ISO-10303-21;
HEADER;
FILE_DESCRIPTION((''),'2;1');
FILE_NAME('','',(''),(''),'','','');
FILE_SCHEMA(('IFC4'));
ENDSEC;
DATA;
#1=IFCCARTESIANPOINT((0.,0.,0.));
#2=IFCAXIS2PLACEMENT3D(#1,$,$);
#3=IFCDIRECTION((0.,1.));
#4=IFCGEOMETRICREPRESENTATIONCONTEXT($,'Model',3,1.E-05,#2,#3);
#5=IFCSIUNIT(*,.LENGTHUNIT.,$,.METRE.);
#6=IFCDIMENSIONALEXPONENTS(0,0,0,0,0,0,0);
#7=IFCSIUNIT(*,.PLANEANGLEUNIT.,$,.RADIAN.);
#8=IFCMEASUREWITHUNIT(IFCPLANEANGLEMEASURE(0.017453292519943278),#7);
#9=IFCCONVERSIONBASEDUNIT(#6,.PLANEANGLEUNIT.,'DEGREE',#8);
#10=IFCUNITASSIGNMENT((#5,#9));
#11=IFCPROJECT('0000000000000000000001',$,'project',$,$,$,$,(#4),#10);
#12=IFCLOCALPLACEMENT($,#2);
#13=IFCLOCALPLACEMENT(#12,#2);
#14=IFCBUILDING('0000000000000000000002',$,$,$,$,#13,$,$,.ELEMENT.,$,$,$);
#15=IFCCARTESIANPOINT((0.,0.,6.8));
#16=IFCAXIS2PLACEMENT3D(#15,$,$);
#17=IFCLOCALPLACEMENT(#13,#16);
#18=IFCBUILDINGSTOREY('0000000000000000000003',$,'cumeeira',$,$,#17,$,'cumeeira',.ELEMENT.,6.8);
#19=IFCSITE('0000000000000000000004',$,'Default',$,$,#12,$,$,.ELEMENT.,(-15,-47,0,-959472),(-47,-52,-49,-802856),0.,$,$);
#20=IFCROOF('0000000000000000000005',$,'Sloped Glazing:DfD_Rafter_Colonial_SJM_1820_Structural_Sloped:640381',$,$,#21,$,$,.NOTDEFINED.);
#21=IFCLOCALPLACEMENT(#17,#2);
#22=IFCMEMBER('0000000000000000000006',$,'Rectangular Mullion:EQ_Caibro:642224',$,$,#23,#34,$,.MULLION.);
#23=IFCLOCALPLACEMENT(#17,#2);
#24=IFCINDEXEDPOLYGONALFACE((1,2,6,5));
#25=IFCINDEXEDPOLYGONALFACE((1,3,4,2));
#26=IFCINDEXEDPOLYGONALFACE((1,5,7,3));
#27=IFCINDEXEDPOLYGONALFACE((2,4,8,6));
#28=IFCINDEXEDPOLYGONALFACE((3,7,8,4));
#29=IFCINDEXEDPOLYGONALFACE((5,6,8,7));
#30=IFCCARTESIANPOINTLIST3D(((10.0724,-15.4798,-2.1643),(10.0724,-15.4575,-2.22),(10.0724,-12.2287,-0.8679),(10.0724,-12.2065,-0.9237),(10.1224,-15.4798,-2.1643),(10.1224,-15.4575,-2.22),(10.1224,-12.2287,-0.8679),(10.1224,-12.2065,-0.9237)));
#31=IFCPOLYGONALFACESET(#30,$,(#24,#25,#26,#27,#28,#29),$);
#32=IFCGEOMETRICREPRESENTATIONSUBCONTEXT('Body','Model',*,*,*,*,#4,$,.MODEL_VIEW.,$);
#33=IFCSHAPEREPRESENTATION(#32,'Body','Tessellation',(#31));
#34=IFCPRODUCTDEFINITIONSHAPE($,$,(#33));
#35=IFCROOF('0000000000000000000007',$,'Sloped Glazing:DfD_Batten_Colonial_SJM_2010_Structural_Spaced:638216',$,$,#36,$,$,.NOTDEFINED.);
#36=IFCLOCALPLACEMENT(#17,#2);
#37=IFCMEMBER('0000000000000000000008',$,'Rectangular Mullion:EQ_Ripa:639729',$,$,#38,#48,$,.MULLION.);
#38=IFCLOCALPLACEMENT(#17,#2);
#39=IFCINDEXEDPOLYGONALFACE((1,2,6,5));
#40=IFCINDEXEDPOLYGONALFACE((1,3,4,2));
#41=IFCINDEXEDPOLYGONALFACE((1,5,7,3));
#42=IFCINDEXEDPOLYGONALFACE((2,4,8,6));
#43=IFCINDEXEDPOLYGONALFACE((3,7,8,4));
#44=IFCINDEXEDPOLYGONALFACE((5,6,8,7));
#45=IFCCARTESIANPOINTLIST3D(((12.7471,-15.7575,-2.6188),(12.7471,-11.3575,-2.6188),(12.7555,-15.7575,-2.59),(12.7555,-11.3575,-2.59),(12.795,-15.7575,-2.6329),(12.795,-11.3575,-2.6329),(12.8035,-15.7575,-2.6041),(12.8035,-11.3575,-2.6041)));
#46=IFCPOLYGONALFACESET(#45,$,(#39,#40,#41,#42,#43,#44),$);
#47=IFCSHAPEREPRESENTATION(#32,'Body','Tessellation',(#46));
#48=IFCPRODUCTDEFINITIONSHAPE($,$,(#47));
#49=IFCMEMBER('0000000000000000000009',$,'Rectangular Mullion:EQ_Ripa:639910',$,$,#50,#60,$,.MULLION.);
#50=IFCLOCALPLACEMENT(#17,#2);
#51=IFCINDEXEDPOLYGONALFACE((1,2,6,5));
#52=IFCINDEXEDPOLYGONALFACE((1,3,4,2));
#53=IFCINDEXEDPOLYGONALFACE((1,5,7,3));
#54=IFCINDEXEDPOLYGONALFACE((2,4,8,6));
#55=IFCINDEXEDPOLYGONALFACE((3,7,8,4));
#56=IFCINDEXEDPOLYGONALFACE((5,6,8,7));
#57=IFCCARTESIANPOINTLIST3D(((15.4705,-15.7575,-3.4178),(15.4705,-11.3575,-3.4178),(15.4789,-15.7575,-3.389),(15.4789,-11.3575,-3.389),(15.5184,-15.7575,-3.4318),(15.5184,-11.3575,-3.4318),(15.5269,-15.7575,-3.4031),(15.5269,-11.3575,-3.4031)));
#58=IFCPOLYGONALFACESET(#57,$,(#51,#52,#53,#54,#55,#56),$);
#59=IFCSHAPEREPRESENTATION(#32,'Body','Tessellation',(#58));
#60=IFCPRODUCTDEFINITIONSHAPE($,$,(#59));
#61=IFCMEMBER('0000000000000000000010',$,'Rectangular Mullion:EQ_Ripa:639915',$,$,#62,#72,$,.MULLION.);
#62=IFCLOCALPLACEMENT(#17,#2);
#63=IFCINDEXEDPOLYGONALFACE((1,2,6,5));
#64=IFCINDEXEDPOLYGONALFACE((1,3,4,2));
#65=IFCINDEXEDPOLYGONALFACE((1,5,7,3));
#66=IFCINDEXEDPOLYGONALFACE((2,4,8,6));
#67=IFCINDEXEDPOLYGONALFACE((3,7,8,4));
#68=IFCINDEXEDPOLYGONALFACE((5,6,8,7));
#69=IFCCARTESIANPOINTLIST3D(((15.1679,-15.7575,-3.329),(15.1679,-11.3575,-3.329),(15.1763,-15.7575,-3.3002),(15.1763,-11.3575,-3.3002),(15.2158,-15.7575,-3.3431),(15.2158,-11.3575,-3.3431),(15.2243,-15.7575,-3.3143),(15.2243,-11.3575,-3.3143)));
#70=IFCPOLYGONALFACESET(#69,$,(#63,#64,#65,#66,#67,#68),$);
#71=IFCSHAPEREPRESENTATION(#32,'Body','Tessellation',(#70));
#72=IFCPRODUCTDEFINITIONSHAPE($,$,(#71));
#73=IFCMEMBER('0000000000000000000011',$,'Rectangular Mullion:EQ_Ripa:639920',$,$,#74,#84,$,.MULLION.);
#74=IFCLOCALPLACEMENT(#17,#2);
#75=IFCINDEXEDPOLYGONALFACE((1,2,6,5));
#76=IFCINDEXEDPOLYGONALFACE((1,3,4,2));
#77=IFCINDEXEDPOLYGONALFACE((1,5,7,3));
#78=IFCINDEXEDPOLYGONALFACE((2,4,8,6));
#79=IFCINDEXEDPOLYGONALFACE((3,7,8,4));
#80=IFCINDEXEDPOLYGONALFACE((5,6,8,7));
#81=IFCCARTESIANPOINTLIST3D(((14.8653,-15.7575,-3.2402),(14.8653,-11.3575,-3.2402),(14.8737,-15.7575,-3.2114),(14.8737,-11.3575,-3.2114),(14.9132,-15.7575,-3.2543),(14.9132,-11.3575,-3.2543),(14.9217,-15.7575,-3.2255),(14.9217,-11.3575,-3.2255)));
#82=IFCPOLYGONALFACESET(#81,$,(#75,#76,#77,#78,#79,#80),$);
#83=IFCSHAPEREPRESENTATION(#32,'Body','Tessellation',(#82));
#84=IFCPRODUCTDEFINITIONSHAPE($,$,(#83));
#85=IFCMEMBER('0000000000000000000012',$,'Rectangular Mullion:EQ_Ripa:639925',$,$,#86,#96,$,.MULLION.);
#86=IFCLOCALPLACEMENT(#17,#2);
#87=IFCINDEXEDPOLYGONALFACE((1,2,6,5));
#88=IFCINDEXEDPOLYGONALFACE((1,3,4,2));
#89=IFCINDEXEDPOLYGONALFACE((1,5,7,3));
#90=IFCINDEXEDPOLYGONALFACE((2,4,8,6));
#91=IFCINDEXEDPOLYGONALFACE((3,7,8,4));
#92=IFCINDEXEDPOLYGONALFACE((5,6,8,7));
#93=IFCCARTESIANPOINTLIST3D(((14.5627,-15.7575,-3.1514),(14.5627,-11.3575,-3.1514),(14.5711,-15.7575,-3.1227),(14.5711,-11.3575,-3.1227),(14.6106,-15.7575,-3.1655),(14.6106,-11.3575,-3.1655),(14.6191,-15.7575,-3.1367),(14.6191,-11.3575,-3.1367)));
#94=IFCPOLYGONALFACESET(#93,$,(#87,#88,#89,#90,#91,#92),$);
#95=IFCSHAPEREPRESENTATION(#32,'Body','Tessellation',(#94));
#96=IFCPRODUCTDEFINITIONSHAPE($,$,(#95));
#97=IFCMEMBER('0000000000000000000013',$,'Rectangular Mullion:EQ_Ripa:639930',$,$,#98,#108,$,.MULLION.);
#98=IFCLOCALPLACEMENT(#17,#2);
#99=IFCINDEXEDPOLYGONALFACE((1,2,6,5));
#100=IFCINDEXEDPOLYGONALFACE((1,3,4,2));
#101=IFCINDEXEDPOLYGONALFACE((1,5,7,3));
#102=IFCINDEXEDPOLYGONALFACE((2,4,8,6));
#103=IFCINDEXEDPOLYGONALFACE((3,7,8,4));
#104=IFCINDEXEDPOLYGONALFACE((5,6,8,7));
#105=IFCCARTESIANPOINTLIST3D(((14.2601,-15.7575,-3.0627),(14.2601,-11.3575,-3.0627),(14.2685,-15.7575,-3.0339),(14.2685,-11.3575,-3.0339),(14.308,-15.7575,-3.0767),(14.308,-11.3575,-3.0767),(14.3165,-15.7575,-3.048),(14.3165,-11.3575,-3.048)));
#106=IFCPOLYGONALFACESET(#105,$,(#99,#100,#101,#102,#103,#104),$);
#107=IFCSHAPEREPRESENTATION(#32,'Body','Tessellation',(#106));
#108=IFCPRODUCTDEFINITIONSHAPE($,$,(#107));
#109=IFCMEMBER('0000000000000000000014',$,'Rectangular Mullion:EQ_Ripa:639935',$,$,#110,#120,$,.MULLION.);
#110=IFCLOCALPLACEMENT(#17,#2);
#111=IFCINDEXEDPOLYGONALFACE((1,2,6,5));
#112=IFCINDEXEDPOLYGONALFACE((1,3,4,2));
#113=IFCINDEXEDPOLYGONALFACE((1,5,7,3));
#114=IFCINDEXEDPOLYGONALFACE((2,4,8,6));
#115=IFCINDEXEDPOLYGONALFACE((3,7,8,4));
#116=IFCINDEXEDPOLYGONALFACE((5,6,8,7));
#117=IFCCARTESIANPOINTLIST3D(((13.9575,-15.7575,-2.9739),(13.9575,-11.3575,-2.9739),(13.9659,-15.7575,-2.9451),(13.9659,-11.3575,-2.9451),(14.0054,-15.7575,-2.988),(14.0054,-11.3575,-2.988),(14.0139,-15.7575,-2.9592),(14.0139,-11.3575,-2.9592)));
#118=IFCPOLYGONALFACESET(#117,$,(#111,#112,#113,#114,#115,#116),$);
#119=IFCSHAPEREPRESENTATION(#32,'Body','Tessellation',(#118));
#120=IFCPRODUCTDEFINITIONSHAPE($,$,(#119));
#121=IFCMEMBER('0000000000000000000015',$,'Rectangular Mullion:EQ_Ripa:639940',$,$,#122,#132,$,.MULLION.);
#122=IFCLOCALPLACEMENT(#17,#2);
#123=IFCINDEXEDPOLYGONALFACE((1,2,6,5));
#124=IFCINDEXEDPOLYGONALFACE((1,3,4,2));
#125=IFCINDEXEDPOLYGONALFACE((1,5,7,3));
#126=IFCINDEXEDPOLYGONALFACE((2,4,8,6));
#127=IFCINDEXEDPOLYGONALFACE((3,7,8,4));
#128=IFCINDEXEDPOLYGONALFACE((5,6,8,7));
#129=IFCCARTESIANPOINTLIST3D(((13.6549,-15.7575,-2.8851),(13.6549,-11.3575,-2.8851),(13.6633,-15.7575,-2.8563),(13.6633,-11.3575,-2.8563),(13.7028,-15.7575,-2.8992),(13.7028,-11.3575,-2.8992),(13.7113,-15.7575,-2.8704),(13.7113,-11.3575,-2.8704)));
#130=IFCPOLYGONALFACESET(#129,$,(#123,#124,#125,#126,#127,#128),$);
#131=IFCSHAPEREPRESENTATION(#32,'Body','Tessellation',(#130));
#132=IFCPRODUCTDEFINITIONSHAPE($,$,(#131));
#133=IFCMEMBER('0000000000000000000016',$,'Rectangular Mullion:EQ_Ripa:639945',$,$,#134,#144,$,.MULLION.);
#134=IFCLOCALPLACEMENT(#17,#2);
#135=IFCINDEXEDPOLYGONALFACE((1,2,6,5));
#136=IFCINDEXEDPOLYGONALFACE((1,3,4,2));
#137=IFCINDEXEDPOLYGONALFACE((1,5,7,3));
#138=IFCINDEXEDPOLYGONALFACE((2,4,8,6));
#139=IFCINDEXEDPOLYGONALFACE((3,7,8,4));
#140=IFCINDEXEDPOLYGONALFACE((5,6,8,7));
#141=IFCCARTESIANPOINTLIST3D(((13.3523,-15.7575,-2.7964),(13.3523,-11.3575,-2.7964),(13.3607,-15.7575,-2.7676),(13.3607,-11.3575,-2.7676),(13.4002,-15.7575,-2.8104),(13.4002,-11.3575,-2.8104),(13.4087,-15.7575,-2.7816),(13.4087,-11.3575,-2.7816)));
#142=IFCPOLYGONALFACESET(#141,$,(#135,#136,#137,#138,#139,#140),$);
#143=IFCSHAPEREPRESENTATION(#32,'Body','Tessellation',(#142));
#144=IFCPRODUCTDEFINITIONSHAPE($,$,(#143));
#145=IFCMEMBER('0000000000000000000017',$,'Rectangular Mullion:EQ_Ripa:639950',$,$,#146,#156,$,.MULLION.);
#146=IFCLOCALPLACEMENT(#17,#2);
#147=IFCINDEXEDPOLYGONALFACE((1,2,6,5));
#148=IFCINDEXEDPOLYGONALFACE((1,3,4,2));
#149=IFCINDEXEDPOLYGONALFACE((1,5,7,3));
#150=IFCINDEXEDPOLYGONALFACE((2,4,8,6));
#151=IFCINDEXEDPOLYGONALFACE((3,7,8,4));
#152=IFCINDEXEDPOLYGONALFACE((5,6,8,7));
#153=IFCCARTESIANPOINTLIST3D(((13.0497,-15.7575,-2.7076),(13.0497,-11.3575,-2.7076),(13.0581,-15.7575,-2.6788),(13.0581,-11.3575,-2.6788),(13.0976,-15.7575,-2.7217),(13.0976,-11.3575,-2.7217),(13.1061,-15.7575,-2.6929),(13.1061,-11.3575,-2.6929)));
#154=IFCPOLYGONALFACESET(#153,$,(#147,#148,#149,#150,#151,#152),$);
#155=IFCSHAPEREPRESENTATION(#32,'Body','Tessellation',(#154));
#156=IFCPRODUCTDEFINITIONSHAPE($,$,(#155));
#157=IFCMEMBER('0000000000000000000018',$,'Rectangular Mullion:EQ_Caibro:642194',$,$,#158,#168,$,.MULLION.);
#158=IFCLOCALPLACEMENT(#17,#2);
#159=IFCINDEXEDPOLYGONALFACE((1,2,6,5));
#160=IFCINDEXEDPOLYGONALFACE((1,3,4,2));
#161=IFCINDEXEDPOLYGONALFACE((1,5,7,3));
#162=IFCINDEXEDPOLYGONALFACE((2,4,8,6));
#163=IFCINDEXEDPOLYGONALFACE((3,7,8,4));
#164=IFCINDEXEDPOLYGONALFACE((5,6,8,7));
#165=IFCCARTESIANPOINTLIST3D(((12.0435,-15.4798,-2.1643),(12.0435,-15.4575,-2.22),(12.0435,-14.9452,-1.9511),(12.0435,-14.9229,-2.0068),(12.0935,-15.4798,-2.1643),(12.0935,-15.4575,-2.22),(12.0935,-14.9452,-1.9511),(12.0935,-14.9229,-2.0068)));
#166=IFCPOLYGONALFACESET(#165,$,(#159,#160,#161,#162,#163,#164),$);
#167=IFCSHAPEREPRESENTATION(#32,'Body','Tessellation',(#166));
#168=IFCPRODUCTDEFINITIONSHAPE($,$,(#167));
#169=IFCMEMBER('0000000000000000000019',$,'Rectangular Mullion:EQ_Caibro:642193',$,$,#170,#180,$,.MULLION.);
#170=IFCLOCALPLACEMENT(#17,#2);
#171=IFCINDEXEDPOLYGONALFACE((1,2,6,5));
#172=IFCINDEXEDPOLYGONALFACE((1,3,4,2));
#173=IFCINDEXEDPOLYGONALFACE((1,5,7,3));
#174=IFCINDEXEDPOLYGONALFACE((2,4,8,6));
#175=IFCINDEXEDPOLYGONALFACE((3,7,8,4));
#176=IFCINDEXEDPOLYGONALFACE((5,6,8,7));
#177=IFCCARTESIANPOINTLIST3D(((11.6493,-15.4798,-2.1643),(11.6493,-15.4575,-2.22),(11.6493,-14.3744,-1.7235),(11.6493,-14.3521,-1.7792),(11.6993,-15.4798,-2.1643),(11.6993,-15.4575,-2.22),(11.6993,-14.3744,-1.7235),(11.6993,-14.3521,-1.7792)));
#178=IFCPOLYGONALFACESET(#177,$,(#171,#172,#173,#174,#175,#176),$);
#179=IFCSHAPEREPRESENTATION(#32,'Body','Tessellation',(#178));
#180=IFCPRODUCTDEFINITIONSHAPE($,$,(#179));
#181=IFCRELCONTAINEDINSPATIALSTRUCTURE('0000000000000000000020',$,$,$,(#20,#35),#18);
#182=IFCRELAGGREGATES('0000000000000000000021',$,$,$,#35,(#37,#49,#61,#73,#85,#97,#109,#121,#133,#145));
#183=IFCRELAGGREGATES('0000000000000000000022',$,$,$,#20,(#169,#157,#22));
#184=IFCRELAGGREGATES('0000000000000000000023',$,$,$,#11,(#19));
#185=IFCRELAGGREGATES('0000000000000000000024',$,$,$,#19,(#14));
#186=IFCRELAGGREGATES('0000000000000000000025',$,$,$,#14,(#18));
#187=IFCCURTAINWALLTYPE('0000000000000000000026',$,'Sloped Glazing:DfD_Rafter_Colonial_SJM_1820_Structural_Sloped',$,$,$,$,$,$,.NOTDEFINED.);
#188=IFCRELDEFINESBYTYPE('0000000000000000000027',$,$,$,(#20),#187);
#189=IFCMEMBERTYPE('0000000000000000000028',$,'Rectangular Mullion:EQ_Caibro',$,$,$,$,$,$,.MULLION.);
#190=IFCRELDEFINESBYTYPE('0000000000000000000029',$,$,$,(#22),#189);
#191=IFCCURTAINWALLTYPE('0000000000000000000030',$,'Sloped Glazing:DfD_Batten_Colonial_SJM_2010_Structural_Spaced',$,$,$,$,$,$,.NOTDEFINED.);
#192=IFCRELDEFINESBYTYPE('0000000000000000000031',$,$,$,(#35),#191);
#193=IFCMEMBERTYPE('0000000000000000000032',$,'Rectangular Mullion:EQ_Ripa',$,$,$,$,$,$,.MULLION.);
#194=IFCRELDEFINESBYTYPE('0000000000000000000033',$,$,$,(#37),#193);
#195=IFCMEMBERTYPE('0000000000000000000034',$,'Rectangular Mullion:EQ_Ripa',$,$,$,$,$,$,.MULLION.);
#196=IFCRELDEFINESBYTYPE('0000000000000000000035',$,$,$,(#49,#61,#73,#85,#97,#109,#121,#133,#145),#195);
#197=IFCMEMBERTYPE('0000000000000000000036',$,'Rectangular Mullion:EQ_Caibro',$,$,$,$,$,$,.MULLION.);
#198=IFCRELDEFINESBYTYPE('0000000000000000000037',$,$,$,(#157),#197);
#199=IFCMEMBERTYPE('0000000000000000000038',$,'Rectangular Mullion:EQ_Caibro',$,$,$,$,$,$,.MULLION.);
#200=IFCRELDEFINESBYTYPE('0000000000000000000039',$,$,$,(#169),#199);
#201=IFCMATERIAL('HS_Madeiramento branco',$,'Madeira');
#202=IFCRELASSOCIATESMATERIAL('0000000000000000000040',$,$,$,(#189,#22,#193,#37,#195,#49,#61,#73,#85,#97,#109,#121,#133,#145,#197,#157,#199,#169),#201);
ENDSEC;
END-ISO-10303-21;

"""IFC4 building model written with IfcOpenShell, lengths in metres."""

from ifc_helpers import new_model, entity, si_unit, converted_unit, direction, frame, origin, place, context, subcontext, project, spatial, indexed_curve, outline, extrude, source, transform, mapped, material, type_object, type_shapes, element, aggregate, save


model = new_model("IFC4")

# Units and contexts
model_context = context("Model", 3, precision=1e-05, world=origin(), true_north=direction((0.0, 1.0)))
body_context = subcontext(model_context, "Body", "Model", "MODEL_VIEW")
ifc_project = project(units=[si_unit("LENGTHUNIT", "METRE"), converted_unit("PLANEANGLEUNIT", "DEGREE", entity("IfcPlaneAngleMeasure", 0.017453292519943278), si_unit("PLANEANGLEUNIT", "RADIAN"), dimensions=[0, 0, 0, 0, 0, 0, 0])], contexts=[model_context])

# Site, building, storey
site_placement = place(None, origin())
site = spatial("IfcSite", under=ifc_project, at=site_placement, Name="Default", CompositionType="ELEMENT", RefLatitude=(-15, -47, 0, -959472), RefLongitude=(-47, -52, -49, -802856), RefElevation=0.0)
building_placement = place(site_placement, origin())
building = spatial("IfcBuilding", under=site, at=building_placement, CompositionType="ELEMENT")
storey_placement = place(building_placement, frame((0.0, 0.0, 6.8)))
storey = spatial("IfcBuildingStorey", under=building, at=storey_placement, Name="cumeeira", LongName="cumeeira", CompositionType="ELEMENT", Elevation=6.8)

# Roof, member
curtain_wall_type_1 = type_object("IfcCurtainWallType", Name="Sloped Glazing:DfD_Rafter_Colonial_SJM_1820_Structural_Sloped", PredefinedType="NOTDEFINED")
roof_1_placement = place(storey_placement, frame((0.0, 0.0, -6.8)))
roof_1 = element("IfcRoof", 1, at=roof_1_placement, inside=storey, type_object=curtain_wall_type_1, Name="Sloped Glazing:DfD_Rafter_Colonial_SJM_1820_Structural_Sloped:640381", PredefinedType="NOTDEFINED")
ifc_material_1 = material(Name="HS_Madeiramento branco", Category="Madeira")
member_type_1 = type_object("IfcMemberType", Name="Rectangular Mullion:EQ_Caibro", PredefinedType="MULLION", material=ifc_material_1)
shared_shape_1 = source(origin(), body_context, "Body", "SweptSolid", [
    extrude(outline(indexed_curve([(-0.025, -0.03), (0.025, -0.03), (0.025, 0.03), (-0.025, 0.03), (-0.025, -0.03)], self_intersect=False)), frame((0.0, -0.03, -3.5), z_axis=(0.0, 0.0, 1.0), x_axis=(-1.0, 0.0, 0.0)), (0.0, 0.0, 1.0), 3.5),
])
type_shapes(member_type_1, [shared_shape_1])
member_1_placement = place(roof_1_placement, frame((10.0974, -12.2065, 5.8763), z_axis=(0.0, 0.928878, 0.370385), x_axis=(1.0, 0.0, 0.0)))
member_1 = element("IfcMember", 2, at=member_1_placement, type_object=member_type_1, material=ifc_material_1, Name="Rectangular Mullion:EQ_Caibro:642224", PredefinedType="MULLION", context=body_context, shape_type="MappedRepresentation", body=[
    mapped(shared_shape_1, transform((0.0, 0.0, 0.0), scale=1.0)),
])

# Roof, members
curtain_wall_type_2 = type_object("IfcCurtainWallType", Name="Sloped Glazing:DfD_Batten_Colonial_SJM_2010_Structural_Spaced", PredefinedType="NOTDEFINED")
roof_2_placement = place(storey_placement, frame((0.0, 0.0, -6.8)))
roof_2 = element("IfcRoof", 3, at=roof_2_placement, inside=storey, type_object=curtain_wall_type_2, Name="Sloped Glazing:DfD_Batten_Colonial_SJM_2010_Structural_Spaced:638216", PredefinedType="NOTDEFINED")
member_type_2 = type_object("IfcMemberType", Name="Rectangular Mullion:EQ_Ripa", PredefinedType="MULLION", material=ifc_material_1)
shared_shape_2 = source(origin(), body_context, "Body", "SweptSolid", [
    extrude(outline(indexed_curve([(-0.025, -0.015), (0.025, -0.015), (0.025, 0.015), (-0.025, 0.015), (-0.025, -0.015)], self_intersect=False)), frame((-0.025, 0.0, -4.4), z_axis=(0.0, 0.0, 1.0), x_axis=(-1.0, 0.0, 0.0)), (0.0, 0.0, 1.0), 4.4),
])
type_shapes(member_type_2, [shared_shape_2])
member_2_placement = place(roof_2_placement, frame((12.7513, -15.7575, 4.1956), z_axis=(0.0, -1.0, 0.0), x_axis=(-0.95956, 0.0, 0.281504)))
member_2 = element("IfcMember", 4, at=member_2_placement, type_object=member_type_2, material=ifc_material_1, Name="Rectangular Mullion:EQ_Ripa:639729", PredefinedType="MULLION", context=body_context, shape_type="MappedRepresentation", body=[
    mapped(shared_shape_2, transform((0.0, 0.0, 0.0), scale=1.0)),
])
member_type_3 = type_object("IfcMemberType", Name="Rectangular Mullion:EQ_Ripa", PredefinedType="MULLION", material=ifc_material_1)
shared_shape_3 = source(origin(), body_context, "Body", "SweptSolid", [
    extrude(outline(indexed_curve([(-0.025, -0.015), (0.025, -0.015), (0.025, 0.015), (-0.025, 0.015), (-0.025, -0.015)], self_intersect=False)), frame((0.0, 0.0, -4.4), z_axis=(0.0, 0.0, 1.0), x_axis=(-1.0, 0.0, 0.0)), (0.0, 0.0, 1.0), 4.4),
])
type_shapes(member_type_3, [shared_shape_3])
member_3_placement = place(roof_2_placement, frame((15.4987, -15.7575, 3.3896), z_axis=(0.0, -1.0, 0.0), x_axis=(-0.95956, 0.0, 0.281504)))
member_3 = element("IfcMember", 5, at=member_3_placement, type_object=member_type_3, material=ifc_material_1, Name="Rectangular Mullion:EQ_Ripa:639910", PredefinedType="MULLION", context=body_context, shape_type="MappedRepresentation", body=[
    mapped(shared_shape_3, transform((0.0, 0.0, 0.0), scale=1.0)),
])
member_4_placement = place(roof_2_placement, frame((15.1961, -15.7575, 3.4784), z_axis=(0.0, -1.0, 0.0), x_axis=(-0.95956, 0.0, 0.281504)))
member_4 = element("IfcMember", 6, at=member_4_placement, type_object=member_type_3, material=ifc_material_1, Name="Rectangular Mullion:EQ_Ripa:639915", PredefinedType="MULLION", context=body_context, shape_type="MappedRepresentation", body=[
    mapped(shared_shape_3, transform((0.0, 0.0, 0.0), scale=1.0)),
])
member_5_placement = place(roof_2_placement, frame((14.8935, -15.7575, 3.5671), z_axis=(0.0, -1.0, 0.0), x_axis=(-0.95956, 0.0, 0.281504)))
member_5 = element("IfcMember", 7, at=member_5_placement, type_object=member_type_3, material=ifc_material_1, Name="Rectangular Mullion:EQ_Ripa:639920", PredefinedType="MULLION", context=body_context, shape_type="MappedRepresentation", body=[
    mapped(shared_shape_3, transform((0.0, 0.0, 0.0), scale=1.0)),
])
member_6_placement = place(roof_2_placement, frame((14.5909, -15.7575, 3.6559), z_axis=(0.0, -1.0, 0.0), x_axis=(-0.95956, 0.0, 0.281504)))
member_6 = element("IfcMember", 8, at=member_6_placement, type_object=member_type_3, material=ifc_material_1, Name="Rectangular Mullion:EQ_Ripa:639925", PredefinedType="MULLION", context=body_context, shape_type="MappedRepresentation", body=[
    mapped(shared_shape_3, transform((0.0, 0.0, 0.0), scale=1.0)),
])
member_7_placement = place(roof_2_placement, frame((14.2883, -15.7575, 3.7447), z_axis=(0.0, -1.0, 0.0), x_axis=(-0.95956, 0.0, 0.281504)))
member_7 = element("IfcMember", 9, at=member_7_placement, type_object=member_type_3, material=ifc_material_1, Name="Rectangular Mullion:EQ_Ripa:639930", PredefinedType="MULLION", context=body_context, shape_type="MappedRepresentation", body=[
    mapped(shared_shape_3, transform((0.0, 0.0, 0.0), scale=1.0)),
])
member_8_placement = place(roof_2_placement, frame((13.9857, -15.7575, 3.8335), z_axis=(0.0, -1.0, 0.0), x_axis=(-0.95956, 0.0, 0.281504)))
member_8 = element("IfcMember", 10, at=member_8_placement, type_object=member_type_3, material=ifc_material_1, Name="Rectangular Mullion:EQ_Ripa:639935", PredefinedType="MULLION", context=body_context, shape_type="MappedRepresentation", body=[
    mapped(shared_shape_3, transform((0.0, 0.0, 0.0), scale=1.0)),
])
member_9_placement = place(roof_2_placement, frame((13.6831, -15.7575, 3.9222), z_axis=(0.0, -1.0, 0.0), x_axis=(-0.95956, 0.0, 0.281504)))
member_9 = element("IfcMember", 11, at=member_9_placement, type_object=member_type_3, material=ifc_material_1, Name="Rectangular Mullion:EQ_Ripa:639940", PredefinedType="MULLION", context=body_context, shape_type="MappedRepresentation", body=[
    mapped(shared_shape_3, transform((0.0, 0.0, 0.0), scale=1.0)),
])
member_10_placement = place(roof_2_placement, frame((13.3805, -15.7575, 4.011), z_axis=(0.0, -1.0, 0.0), x_axis=(-0.95956, 0.0, 0.281504)))
member_10 = element("IfcMember", 12, at=member_10_placement, type_object=member_type_3, material=ifc_material_1, Name="Rectangular Mullion:EQ_Ripa:639945", PredefinedType="MULLION", context=body_context, shape_type="MappedRepresentation", body=[
    mapped(shared_shape_3, transform((0.0, 0.0, 0.0), scale=1.0)),
])
member_11_placement = place(roof_2_placement, frame((13.0779, -15.7575, 4.0998), z_axis=(0.0, -1.0, 0.0), x_axis=(-0.95956, 0.0, 0.281504)))
member_11 = element("IfcMember", 13, at=member_11_placement, type_object=member_type_3, material=ifc_material_1, Name="Rectangular Mullion:EQ_Ripa:639950", PredefinedType="MULLION", context=body_context, shape_type="MappedRepresentation", body=[
    mapped(shared_shape_3, transform((0.0, 0.0, 0.0), scale=1.0)),
])
aggregate(roof_2, [member_2, member_3, member_4, member_5, member_6, member_7, member_8, member_9, member_10, member_11])

# Members
member_type_4 = type_object("IfcMemberType", Name="Rectangular Mullion:EQ_Caibro", PredefinedType="MULLION", material=ifc_material_1)
shared_shape_4 = source(origin(), body_context, "Body", "SweptSolid", [
    extrude(outline(indexed_curve([(-0.025, -0.03), (0.025, -0.03), (0.025, 0.03), (-0.025, 0.03), (-0.025, -0.03)], self_intersect=False)), frame((0.0, -0.03, -0.5755), z_axis=(0.0, 0.0, 1.0), x_axis=(-1.0, 0.0, 0.0)), (0.0, 0.0, 1.0), 0.5755),
])
type_shapes(member_type_4, [shared_shape_4])
member_12_placement = place(roof_1_placement, frame((12.0685, -14.9229, 4.7932), z_axis=(0.0, 0.928878, 0.370385), x_axis=(1.0, 0.0, 0.0)))
member_12 = element("IfcMember", 14, at=member_12_placement, type_object=member_type_4, material=ifc_material_1, Name="Rectangular Mullion:EQ_Caibro:642194", PredefinedType="MULLION", context=body_context, shape_type="MappedRepresentation", body=[
    mapped(shared_shape_4, transform((0.0, 0.0, 0.0), scale=1.0)),
])
member_type_5 = type_object("IfcMemberType", Name="Rectangular Mullion:EQ_Caibro", PredefinedType="MULLION", material=ifc_material_1)
shared_shape_5 = source(origin(), body_context, "Body", "SweptSolid", [
    extrude(outline(indexed_curve([(-0.025, -0.03), (0.025, -0.03), (0.025, 0.03), (-0.025, 0.03), (-0.025, -0.03)], self_intersect=False)), frame((0.0, -0.03, -1.19), z_axis=(0.0, 0.0, 1.0), x_axis=(-1.0, 0.0, 0.0)), (0.0, 0.0, 1.0), 1.19),
])
type_shapes(member_type_5, [shared_shape_5])
member_13_placement = place(roof_1_placement, frame((11.6743, -14.3521, 5.0208), z_axis=(0.0, 0.928878, 0.370385), x_axis=(1.0, 0.0, 0.0)))
member_13 = element("IfcMember", 15, at=member_13_placement, type_object=member_type_5, material=ifc_material_1, Name="Rectangular Mullion:EQ_Caibro:642193", PredefinedType="MULLION", context=body_context, shape_type="MappedRepresentation", body=[
    mapped(shared_shape_5, transform((0.0, 0.0, 0.0), scale=1.0)),
])
aggregate(roof_1, [member_13, member_12, member_1])

save(model, "model.ifc")
